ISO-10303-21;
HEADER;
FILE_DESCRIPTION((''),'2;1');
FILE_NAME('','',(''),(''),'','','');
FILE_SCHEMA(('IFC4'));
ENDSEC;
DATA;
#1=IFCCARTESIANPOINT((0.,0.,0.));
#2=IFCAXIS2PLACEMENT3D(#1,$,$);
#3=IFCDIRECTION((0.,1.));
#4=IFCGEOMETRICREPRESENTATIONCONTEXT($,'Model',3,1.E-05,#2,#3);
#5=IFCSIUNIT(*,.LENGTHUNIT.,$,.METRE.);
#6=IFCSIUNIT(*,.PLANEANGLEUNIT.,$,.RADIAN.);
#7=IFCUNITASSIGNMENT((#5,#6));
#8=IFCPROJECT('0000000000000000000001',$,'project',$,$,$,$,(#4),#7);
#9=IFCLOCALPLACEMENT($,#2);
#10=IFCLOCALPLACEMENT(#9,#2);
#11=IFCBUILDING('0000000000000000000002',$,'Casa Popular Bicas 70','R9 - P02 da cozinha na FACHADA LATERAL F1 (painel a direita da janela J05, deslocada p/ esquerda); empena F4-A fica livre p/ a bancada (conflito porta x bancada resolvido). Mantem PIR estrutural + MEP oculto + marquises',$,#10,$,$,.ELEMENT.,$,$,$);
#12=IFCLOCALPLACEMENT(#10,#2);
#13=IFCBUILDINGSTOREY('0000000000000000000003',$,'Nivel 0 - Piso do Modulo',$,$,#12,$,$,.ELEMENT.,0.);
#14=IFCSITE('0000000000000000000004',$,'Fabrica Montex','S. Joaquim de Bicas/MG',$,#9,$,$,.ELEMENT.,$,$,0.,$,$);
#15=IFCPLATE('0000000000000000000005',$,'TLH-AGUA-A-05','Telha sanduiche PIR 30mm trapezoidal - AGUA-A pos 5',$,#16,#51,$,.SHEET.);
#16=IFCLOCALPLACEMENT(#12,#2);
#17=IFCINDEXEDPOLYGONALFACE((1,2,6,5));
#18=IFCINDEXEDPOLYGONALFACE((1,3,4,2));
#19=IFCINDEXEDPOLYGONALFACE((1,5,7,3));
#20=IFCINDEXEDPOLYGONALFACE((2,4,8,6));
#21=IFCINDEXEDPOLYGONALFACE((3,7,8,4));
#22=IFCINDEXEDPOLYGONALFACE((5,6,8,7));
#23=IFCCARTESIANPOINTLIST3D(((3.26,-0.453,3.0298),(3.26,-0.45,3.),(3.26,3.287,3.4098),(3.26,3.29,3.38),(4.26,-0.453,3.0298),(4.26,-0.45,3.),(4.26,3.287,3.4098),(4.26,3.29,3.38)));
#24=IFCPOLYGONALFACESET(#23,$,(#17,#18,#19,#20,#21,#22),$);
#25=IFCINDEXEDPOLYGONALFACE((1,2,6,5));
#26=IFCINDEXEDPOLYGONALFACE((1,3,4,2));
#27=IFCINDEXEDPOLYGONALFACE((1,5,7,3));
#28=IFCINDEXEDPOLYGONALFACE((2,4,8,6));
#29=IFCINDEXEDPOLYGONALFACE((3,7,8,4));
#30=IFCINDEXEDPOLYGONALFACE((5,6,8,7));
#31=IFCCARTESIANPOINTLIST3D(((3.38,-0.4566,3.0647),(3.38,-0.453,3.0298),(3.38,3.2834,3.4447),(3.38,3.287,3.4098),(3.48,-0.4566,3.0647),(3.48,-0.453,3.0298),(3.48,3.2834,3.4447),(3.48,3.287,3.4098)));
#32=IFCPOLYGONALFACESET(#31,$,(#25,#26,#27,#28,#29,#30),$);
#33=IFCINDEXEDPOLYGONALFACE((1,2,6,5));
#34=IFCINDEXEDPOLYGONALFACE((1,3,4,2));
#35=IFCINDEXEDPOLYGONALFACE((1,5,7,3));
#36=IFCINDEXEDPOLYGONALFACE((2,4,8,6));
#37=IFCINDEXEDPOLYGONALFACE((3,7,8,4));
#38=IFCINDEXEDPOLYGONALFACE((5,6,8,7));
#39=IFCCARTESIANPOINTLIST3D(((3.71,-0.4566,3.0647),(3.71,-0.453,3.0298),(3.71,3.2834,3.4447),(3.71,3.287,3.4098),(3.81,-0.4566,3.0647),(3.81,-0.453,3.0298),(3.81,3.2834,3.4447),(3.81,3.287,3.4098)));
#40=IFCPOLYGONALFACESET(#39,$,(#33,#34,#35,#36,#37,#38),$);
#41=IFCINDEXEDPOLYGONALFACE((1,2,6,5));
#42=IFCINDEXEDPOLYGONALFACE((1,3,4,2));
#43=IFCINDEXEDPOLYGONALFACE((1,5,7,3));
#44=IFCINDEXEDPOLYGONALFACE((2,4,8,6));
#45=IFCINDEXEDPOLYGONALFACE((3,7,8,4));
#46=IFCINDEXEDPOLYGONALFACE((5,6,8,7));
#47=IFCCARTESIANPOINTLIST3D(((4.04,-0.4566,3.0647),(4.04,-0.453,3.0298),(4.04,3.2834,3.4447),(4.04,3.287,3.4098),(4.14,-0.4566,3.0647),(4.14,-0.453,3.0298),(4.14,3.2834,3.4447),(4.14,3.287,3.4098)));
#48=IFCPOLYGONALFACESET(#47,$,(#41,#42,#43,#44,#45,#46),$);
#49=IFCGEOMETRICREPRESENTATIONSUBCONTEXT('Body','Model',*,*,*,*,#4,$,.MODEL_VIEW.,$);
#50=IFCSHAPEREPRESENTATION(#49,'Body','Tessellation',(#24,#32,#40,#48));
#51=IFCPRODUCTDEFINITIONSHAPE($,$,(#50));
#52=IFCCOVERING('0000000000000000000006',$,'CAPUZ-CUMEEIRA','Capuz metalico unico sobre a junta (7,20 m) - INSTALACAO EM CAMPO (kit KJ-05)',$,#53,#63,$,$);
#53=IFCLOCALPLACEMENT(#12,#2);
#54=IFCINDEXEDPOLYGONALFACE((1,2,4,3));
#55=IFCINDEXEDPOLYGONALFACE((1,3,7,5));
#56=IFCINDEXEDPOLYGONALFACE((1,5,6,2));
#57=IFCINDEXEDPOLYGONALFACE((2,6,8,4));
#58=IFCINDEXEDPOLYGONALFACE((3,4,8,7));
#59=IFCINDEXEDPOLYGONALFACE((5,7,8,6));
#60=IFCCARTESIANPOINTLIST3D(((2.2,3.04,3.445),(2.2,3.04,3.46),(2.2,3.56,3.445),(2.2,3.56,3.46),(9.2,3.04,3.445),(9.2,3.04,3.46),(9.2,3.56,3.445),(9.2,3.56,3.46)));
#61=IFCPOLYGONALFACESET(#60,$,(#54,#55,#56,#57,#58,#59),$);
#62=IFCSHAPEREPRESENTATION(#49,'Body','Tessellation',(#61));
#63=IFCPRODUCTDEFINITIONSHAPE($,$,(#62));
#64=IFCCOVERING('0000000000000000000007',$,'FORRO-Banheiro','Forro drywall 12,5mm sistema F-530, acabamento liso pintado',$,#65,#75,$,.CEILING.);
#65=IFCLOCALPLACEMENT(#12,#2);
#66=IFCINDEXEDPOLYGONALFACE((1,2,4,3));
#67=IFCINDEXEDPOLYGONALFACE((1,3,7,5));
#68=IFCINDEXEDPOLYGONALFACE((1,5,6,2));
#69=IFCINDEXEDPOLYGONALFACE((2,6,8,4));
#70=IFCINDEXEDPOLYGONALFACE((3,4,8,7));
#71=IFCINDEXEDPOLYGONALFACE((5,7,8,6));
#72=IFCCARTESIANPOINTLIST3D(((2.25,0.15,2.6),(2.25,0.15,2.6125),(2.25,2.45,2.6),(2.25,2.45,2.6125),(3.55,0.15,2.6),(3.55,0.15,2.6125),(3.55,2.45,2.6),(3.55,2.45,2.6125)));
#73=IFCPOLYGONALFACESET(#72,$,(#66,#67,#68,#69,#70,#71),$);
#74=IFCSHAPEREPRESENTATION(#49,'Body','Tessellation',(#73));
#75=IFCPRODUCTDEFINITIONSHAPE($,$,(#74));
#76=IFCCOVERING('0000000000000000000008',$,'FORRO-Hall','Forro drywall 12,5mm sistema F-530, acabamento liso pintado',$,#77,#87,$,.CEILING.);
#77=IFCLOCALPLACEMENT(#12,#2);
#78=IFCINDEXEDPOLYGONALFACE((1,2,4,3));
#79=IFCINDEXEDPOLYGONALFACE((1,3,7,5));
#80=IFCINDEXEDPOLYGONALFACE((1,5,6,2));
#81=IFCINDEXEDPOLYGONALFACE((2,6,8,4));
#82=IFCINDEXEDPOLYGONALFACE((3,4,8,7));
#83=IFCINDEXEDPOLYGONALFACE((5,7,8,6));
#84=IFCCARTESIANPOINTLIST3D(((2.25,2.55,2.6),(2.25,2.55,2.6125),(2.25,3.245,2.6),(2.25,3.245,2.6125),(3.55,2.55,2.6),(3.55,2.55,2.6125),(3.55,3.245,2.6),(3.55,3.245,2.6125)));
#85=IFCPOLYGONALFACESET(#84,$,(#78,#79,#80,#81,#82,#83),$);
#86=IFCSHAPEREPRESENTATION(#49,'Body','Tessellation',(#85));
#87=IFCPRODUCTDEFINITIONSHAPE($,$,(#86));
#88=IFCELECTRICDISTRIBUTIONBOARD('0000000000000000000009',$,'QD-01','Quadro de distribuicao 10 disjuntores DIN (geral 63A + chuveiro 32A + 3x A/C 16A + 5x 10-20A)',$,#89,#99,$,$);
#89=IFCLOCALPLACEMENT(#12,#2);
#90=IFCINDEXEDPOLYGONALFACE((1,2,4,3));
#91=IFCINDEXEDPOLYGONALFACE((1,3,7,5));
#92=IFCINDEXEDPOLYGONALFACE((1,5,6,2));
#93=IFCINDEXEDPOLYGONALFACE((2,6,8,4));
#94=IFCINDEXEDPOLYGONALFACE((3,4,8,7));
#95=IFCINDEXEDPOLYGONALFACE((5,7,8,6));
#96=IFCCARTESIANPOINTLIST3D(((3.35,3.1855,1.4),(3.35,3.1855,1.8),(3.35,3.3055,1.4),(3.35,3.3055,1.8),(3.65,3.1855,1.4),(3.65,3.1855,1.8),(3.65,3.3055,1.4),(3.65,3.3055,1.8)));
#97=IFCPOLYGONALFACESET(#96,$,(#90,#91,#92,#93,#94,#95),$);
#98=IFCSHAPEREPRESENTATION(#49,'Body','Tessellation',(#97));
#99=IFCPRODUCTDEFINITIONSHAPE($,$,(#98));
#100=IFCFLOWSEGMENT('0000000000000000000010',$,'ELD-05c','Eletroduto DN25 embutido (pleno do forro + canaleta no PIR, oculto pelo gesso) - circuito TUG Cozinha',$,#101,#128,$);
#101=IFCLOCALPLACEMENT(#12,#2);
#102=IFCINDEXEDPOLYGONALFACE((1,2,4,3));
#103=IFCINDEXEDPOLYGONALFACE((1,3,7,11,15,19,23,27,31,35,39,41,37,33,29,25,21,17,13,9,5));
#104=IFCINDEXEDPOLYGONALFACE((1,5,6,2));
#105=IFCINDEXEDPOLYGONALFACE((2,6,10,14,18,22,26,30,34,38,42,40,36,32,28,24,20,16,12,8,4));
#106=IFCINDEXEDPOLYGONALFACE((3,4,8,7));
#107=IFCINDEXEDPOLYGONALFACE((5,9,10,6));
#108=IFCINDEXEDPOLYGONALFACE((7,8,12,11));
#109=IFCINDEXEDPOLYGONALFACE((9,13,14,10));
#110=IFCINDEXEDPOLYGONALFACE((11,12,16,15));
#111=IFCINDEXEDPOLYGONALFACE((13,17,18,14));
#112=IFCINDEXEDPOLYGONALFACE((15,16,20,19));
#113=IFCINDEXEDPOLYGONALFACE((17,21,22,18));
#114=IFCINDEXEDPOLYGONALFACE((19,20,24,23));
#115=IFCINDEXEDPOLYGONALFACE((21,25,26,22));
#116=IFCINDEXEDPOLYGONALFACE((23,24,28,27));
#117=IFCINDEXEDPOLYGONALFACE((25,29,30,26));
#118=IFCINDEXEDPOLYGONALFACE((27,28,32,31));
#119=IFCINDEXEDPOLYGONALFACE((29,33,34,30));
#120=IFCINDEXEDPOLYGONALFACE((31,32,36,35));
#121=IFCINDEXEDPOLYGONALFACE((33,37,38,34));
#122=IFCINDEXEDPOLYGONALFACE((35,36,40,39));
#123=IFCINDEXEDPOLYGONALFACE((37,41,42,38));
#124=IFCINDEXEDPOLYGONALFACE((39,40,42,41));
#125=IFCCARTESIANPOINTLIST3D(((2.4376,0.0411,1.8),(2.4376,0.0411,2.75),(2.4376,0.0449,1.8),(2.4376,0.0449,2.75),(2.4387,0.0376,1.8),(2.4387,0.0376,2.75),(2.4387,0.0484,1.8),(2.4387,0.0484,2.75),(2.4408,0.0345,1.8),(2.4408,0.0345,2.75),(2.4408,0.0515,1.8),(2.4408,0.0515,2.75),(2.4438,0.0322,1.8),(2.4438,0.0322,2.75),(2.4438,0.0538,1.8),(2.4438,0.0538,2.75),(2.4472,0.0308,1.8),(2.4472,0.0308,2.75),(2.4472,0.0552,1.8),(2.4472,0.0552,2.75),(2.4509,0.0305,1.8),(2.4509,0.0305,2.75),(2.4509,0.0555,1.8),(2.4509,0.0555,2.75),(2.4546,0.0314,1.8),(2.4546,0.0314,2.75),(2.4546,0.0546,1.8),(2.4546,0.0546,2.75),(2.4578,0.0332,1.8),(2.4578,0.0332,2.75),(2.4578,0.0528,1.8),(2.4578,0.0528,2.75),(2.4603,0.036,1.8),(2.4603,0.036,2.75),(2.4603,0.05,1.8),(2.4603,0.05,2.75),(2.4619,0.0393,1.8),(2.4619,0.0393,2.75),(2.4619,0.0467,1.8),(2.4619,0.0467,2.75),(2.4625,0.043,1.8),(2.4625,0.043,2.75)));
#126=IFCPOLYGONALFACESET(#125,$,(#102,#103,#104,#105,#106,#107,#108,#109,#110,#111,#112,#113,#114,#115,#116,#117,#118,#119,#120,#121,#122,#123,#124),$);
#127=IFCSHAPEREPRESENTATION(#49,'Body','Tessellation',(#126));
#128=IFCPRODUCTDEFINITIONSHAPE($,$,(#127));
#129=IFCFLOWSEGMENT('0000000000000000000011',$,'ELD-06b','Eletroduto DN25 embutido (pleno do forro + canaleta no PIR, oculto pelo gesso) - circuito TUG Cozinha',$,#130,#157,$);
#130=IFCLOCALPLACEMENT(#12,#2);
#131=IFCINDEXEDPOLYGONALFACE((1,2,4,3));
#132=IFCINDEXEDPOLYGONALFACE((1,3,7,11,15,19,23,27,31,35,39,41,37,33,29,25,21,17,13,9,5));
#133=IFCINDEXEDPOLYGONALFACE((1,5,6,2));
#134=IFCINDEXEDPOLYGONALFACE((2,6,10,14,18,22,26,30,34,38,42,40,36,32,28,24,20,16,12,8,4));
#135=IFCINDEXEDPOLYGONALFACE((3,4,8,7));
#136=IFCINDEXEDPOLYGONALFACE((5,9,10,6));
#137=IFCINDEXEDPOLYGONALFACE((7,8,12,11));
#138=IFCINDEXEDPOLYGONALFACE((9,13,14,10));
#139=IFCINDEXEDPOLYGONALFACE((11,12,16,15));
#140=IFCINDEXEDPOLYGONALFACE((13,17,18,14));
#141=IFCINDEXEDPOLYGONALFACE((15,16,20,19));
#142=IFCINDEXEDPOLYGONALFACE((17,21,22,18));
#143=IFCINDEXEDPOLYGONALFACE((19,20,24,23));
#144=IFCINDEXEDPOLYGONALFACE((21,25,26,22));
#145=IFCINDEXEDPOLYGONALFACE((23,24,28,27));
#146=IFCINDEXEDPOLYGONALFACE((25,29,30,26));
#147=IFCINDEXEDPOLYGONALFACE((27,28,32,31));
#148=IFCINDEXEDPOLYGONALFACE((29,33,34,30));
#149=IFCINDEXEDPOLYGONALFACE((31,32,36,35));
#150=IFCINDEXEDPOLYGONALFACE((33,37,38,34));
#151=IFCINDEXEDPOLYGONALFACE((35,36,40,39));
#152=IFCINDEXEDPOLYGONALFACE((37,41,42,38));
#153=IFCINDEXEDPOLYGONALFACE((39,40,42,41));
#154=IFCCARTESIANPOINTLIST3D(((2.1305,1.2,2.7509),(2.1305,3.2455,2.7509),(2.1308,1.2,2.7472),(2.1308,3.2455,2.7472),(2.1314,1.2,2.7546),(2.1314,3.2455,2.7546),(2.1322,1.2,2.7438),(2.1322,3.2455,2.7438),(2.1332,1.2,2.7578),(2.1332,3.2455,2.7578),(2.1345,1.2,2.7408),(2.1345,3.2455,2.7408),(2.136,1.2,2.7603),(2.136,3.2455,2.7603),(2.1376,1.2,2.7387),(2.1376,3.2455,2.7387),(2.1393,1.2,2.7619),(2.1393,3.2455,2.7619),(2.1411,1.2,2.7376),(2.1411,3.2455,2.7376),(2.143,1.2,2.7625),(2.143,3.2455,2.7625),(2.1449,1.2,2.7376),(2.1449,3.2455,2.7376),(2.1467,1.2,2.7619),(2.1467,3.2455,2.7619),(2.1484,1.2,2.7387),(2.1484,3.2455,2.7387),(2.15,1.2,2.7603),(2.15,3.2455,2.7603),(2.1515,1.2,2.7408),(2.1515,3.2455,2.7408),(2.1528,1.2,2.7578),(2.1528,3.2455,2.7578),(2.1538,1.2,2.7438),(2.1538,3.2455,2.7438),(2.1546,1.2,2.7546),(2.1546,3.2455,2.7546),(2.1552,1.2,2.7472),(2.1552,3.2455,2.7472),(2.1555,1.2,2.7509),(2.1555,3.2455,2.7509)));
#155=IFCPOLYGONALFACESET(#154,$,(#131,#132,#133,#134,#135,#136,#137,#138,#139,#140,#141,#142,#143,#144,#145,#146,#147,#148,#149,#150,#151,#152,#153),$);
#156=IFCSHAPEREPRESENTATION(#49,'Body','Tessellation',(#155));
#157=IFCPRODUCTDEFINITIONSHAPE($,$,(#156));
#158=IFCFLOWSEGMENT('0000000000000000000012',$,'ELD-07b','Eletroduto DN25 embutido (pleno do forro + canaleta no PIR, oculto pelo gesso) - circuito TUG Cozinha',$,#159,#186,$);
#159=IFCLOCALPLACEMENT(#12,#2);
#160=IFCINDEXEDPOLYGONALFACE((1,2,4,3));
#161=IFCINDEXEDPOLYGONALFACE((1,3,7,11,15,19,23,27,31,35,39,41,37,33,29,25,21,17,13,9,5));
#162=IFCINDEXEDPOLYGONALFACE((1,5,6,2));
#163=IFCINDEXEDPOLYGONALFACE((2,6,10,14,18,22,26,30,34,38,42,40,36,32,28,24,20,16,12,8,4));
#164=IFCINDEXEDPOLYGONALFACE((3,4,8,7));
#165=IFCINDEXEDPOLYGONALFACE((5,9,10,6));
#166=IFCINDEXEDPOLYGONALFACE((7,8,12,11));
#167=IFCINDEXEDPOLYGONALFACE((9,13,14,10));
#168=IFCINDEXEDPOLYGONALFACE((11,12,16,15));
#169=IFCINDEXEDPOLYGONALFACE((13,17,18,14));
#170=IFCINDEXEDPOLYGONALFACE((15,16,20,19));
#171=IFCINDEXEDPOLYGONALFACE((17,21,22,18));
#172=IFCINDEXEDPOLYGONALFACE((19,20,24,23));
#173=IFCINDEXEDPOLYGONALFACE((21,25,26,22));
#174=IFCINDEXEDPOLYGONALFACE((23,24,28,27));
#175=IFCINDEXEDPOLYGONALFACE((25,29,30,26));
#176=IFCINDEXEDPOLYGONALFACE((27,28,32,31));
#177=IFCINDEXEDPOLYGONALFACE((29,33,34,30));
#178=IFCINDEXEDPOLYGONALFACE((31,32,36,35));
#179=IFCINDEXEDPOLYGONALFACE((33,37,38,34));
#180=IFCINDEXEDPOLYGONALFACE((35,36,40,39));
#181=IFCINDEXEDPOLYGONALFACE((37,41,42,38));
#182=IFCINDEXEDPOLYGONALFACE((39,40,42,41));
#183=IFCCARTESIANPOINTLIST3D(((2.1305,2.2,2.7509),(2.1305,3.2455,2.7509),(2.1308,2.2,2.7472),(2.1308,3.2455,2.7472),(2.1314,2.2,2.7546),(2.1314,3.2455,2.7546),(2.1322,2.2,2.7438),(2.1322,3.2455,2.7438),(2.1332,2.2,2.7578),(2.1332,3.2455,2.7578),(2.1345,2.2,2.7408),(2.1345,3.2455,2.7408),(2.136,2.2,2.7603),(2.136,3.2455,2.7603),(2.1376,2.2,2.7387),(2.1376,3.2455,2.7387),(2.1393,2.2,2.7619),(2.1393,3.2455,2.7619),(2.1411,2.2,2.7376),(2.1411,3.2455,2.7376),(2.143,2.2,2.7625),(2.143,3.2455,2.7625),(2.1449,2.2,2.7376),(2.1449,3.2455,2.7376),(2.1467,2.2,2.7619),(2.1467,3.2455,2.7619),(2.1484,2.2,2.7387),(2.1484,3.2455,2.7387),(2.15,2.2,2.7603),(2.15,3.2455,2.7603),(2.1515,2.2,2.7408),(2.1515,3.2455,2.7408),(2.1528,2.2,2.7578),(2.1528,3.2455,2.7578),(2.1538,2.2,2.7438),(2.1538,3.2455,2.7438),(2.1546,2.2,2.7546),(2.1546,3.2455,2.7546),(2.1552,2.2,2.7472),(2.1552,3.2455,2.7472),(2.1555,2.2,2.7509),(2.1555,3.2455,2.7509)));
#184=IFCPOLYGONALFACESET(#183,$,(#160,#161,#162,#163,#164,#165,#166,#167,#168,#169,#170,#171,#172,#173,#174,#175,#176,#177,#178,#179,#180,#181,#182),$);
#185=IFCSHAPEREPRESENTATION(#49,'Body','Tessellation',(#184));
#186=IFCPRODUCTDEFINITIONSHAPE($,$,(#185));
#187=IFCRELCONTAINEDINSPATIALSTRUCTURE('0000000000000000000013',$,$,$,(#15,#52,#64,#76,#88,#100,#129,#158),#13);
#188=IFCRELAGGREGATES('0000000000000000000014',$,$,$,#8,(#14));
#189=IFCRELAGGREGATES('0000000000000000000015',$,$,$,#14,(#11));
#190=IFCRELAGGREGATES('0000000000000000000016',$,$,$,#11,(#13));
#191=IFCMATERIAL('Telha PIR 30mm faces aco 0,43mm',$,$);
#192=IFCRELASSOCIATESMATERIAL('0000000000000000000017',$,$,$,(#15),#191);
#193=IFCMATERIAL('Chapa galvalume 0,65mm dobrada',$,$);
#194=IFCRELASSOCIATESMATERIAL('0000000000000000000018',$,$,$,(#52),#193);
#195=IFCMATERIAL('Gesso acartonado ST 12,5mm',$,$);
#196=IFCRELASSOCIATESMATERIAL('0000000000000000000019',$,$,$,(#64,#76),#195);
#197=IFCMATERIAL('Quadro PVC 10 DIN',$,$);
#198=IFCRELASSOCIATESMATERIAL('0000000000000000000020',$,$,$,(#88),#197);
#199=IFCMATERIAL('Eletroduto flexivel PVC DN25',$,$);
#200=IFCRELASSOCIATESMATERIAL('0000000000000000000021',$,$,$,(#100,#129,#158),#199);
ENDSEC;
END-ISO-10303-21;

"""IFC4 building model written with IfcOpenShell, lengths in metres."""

from ifc_helpers import new_model, si_unit, direction, frame, frame_2d, origin, origin_2d, place, context, subcontext, project, spatial, rectangle, circle, extrude, material, element, save


model = new_model("IFC4")

# Units and contexts
model_context = context("Model", 3, precision=1e-05, world=origin(), true_north=direction((0.0, 1.0)))
body_context = subcontext(model_context, "Body", "Model", "MODEL_VIEW")
ifc_project = project(units=[si_unit("LENGTHUNIT", "METRE"), si_unit("PLANEANGLEUNIT", "RADIAN")], contexts=[model_context])

# Site, building, storey
site_placement = place(None, origin())
site = spatial("IfcSite", under=ifc_project, at=site_placement, Name="Fabrica Montex", Description="S. Joaquim de Bicas/MG", CompositionType="ELEMENT", RefElevation=0.0)
building_placement = place(site_placement, origin())
building = spatial("IfcBuilding", under=site, at=building_placement, Name="Casa Popular Bicas 70", Description="R9 - P02 da cozinha na FACHADA LATERAL F1 (painel a direita da janela J05, deslocada p/ esquerda); empena F4-A fica livre p/ a bancada (conflito porta x bancada resolvido). Mantem PIR estrutural + MEP oculto + marquises", CompositionType="ELEMENT")
storey_placement = place(building_placement, origin())
storey = spatial("IfcBuildingStorey", under=building, at=storey_placement, Name="Nivel 0 - Piso do Modulo", CompositionType="ELEMENT", Elevation=0.0)

# Plate
ifc_material_1 = material(Name="Telha PIR 30mm faces aco 0,43mm")
for number, where, z_axis, x_axis, name in (
    (1, (3.26, -0.45, 3.0), (0.0, -0.101084, 0.994878), (1.0, 0.0, 0.0), "TLH-AGUA-A-05"),
):
    element("IfcPlate", number, at=place(storey_placement, frame(where, z_axis=z_axis, x_axis=x_axis)), inside=storey, material=ifc_material_1, Name=name, Description="Telha sanduiche PIR 30mm trapezoidal - AGUA-A pos 5", PredefinedType="SHEET", context=body_context, shape_type="SweptSolid", body=[
        extrude(rectangle(XDim=1.0, YDim=3.7593, at=frame_2d((0.5, 1.8796))), origin(), (0.0, 0.0, 1.0), 0.03),
        extrude(rectangle(XDim=0.1, YDim=3.7593, at=frame_2d((0.17, 1.8796))), frame((0.0, 0.0, 0.03)), (0.0, 0.0, 1.0), 0.035),
        extrude(rectangle(XDim=0.1, YDim=3.7593, at=frame_2d((0.5, 1.8796))), frame((0.0, 0.0, 0.03)), (0.0, 0.0, 1.0), 0.035),
        extrude(rectangle(XDim=0.1, YDim=3.7593, at=frame_2d((0.83, 1.8796))), frame((0.0, 0.0, 0.03)), (0.0, 0.0, 1.0), 0.035),
    ])

# Coverings
ifc_material_2 = material(Name="Chapa galvalume 0,65mm dobrada")
covering_1_placement = place(storey_placement, frame((2.2, 3.04, 3.445), x_axis=(1.0, 0.0, 0.0)))
element("IfcCovering", 2, at=covering_1_placement, inside=storey, material=ifc_material_2, Name="CAPUZ-CUMEEIRA", Description="Capuz metalico unico sobre a junta (7,20 m) - INSTALACAO EM CAMPO (kit KJ-05)", context=body_context, shape_type="SweptSolid", body=[
    extrude(rectangle(XDim=7.0, YDim=0.52, at=frame_2d((3.5, 0.26))), origin(), (0.0, 0.0, 1.0), 0.015),
])
ifc_material_3 = material(Name="Gesso acartonado ST 12,5mm")
covering_2_placement = place(storey_placement, frame((2.25, 0.15, 2.6)))
element("IfcCovering", 3, at=covering_2_placement, inside=storey, material=ifc_material_3, Name="FORRO-Banheiro", Description="Forro drywall 12,5mm sistema F-530, acabamento liso pintado", PredefinedType="CEILING", context=body_context, shape_type="SweptSolid", body=[
    extrude(rectangle(XDim=1.3, YDim=2.3, at=frame_2d((0.65, 1.15))), origin(), (0.0, 0.0, 1.0), 0.0125),
])
covering_3_placement = place(storey_placement, frame((2.25, 2.55, 2.6)))
element("IfcCovering", 4, at=covering_3_placement, inside=storey, material=ifc_material_3, Name="FORRO-Hall", Description="Forro drywall 12,5mm sistema F-530, acabamento liso pintado", PredefinedType="CEILING", context=body_context, shape_type="SweptSolid", body=[
    extrude(rectangle(XDim=1.3, YDim=0.695, at=frame_2d((0.65, 0.3475))), origin(), (0.0, 0.0, 1.0), 0.0125),
])

# Electric distribution board
ifc_material_4 = material(Name="Quadro PVC 10 DIN")
electric_distribution_board_placement = place(storey_placement, frame((3.35, 3.1855, 1.4)))
element("IfcElectricDistributionBoard", 5, at=electric_distribution_board_placement, inside=storey, material=ifc_material_4, Name="QD-01", Description="Quadro de distribuicao 10 disjuntores DIN (geral 63A + chuveiro 32A + 3x A/C 16A + 5x 10-20A)", context=body_context, shape_type="SweptSolid", body=[
    extrude(rectangle(XDim=0.3, YDim=0.12, at=frame_2d((0.15, 0.06))), origin(), (0.0, 0.0, 1.0), 0.4),
])

# Flow segments
ifc_material_5 = material(Name="Eletroduto flexivel PVC DN25")
flow_segment_1_placement = place(storey_placement, frame((2.45, 0.043, 2.75), z_axis=(0.0, 0.0, -1.0), x_axis=(1.0, 0.0, 0.0)))
element("IfcFlowSegment", 6, at=flow_segment_1_placement, inside=storey, material=ifc_material_5, Name="ELD-05c", Description="Eletroduto DN25 embutido (pleno do forro + canaleta no PIR, oculto pelo gesso) - circuito TUG Cozinha", context=body_context, shape_type="SweptSolid", body=[
    extrude(circle(Radius=0.0125, at=origin_2d()), origin(), (0.0, 0.0, 1.0), 0.95),
])
flow_segment_2_placement = place(storey_placement, frame((2.143, 3.2455, 2.75), z_axis=(0.0, -1.0, 0.0), x_axis=(0.0, 0.0, 1.0)))
element("IfcFlowSegment", 7, at=flow_segment_2_placement, inside=storey, material=ifc_material_5, Name="ELD-06b", Description="Eletroduto DN25 embutido (pleno do forro + canaleta no PIR, oculto pelo gesso) - circuito TUG Cozinha", context=body_context, shape_type="SweptSolid", body=[
    extrude(circle(Radius=0.0125, at=origin_2d()), origin(), (0.0, 0.0, 1.0), 2.0455),
])
flow_segment_3_placement = place(storey_placement, frame((2.143, 3.2455, 2.75), z_axis=(0.0, -1.0, 0.0), x_axis=(0.0, 0.0, 1.0)))
element("IfcFlowSegment", 8, at=flow_segment_3_placement, inside=storey, material=ifc_material_5, Name="ELD-07b", Description="Eletroduto DN25 embutido (pleno do forro + canaleta no PIR, oculto pelo gesso) - circuito TUG Cozinha", context=body_context, shape_type="SweptSolid", body=[
    extrude(circle(Radius=0.0125, at=origin_2d()), origin(), (0.0, 0.0, 1.0), 1.0455),
])

save(model, "model.ifc")
